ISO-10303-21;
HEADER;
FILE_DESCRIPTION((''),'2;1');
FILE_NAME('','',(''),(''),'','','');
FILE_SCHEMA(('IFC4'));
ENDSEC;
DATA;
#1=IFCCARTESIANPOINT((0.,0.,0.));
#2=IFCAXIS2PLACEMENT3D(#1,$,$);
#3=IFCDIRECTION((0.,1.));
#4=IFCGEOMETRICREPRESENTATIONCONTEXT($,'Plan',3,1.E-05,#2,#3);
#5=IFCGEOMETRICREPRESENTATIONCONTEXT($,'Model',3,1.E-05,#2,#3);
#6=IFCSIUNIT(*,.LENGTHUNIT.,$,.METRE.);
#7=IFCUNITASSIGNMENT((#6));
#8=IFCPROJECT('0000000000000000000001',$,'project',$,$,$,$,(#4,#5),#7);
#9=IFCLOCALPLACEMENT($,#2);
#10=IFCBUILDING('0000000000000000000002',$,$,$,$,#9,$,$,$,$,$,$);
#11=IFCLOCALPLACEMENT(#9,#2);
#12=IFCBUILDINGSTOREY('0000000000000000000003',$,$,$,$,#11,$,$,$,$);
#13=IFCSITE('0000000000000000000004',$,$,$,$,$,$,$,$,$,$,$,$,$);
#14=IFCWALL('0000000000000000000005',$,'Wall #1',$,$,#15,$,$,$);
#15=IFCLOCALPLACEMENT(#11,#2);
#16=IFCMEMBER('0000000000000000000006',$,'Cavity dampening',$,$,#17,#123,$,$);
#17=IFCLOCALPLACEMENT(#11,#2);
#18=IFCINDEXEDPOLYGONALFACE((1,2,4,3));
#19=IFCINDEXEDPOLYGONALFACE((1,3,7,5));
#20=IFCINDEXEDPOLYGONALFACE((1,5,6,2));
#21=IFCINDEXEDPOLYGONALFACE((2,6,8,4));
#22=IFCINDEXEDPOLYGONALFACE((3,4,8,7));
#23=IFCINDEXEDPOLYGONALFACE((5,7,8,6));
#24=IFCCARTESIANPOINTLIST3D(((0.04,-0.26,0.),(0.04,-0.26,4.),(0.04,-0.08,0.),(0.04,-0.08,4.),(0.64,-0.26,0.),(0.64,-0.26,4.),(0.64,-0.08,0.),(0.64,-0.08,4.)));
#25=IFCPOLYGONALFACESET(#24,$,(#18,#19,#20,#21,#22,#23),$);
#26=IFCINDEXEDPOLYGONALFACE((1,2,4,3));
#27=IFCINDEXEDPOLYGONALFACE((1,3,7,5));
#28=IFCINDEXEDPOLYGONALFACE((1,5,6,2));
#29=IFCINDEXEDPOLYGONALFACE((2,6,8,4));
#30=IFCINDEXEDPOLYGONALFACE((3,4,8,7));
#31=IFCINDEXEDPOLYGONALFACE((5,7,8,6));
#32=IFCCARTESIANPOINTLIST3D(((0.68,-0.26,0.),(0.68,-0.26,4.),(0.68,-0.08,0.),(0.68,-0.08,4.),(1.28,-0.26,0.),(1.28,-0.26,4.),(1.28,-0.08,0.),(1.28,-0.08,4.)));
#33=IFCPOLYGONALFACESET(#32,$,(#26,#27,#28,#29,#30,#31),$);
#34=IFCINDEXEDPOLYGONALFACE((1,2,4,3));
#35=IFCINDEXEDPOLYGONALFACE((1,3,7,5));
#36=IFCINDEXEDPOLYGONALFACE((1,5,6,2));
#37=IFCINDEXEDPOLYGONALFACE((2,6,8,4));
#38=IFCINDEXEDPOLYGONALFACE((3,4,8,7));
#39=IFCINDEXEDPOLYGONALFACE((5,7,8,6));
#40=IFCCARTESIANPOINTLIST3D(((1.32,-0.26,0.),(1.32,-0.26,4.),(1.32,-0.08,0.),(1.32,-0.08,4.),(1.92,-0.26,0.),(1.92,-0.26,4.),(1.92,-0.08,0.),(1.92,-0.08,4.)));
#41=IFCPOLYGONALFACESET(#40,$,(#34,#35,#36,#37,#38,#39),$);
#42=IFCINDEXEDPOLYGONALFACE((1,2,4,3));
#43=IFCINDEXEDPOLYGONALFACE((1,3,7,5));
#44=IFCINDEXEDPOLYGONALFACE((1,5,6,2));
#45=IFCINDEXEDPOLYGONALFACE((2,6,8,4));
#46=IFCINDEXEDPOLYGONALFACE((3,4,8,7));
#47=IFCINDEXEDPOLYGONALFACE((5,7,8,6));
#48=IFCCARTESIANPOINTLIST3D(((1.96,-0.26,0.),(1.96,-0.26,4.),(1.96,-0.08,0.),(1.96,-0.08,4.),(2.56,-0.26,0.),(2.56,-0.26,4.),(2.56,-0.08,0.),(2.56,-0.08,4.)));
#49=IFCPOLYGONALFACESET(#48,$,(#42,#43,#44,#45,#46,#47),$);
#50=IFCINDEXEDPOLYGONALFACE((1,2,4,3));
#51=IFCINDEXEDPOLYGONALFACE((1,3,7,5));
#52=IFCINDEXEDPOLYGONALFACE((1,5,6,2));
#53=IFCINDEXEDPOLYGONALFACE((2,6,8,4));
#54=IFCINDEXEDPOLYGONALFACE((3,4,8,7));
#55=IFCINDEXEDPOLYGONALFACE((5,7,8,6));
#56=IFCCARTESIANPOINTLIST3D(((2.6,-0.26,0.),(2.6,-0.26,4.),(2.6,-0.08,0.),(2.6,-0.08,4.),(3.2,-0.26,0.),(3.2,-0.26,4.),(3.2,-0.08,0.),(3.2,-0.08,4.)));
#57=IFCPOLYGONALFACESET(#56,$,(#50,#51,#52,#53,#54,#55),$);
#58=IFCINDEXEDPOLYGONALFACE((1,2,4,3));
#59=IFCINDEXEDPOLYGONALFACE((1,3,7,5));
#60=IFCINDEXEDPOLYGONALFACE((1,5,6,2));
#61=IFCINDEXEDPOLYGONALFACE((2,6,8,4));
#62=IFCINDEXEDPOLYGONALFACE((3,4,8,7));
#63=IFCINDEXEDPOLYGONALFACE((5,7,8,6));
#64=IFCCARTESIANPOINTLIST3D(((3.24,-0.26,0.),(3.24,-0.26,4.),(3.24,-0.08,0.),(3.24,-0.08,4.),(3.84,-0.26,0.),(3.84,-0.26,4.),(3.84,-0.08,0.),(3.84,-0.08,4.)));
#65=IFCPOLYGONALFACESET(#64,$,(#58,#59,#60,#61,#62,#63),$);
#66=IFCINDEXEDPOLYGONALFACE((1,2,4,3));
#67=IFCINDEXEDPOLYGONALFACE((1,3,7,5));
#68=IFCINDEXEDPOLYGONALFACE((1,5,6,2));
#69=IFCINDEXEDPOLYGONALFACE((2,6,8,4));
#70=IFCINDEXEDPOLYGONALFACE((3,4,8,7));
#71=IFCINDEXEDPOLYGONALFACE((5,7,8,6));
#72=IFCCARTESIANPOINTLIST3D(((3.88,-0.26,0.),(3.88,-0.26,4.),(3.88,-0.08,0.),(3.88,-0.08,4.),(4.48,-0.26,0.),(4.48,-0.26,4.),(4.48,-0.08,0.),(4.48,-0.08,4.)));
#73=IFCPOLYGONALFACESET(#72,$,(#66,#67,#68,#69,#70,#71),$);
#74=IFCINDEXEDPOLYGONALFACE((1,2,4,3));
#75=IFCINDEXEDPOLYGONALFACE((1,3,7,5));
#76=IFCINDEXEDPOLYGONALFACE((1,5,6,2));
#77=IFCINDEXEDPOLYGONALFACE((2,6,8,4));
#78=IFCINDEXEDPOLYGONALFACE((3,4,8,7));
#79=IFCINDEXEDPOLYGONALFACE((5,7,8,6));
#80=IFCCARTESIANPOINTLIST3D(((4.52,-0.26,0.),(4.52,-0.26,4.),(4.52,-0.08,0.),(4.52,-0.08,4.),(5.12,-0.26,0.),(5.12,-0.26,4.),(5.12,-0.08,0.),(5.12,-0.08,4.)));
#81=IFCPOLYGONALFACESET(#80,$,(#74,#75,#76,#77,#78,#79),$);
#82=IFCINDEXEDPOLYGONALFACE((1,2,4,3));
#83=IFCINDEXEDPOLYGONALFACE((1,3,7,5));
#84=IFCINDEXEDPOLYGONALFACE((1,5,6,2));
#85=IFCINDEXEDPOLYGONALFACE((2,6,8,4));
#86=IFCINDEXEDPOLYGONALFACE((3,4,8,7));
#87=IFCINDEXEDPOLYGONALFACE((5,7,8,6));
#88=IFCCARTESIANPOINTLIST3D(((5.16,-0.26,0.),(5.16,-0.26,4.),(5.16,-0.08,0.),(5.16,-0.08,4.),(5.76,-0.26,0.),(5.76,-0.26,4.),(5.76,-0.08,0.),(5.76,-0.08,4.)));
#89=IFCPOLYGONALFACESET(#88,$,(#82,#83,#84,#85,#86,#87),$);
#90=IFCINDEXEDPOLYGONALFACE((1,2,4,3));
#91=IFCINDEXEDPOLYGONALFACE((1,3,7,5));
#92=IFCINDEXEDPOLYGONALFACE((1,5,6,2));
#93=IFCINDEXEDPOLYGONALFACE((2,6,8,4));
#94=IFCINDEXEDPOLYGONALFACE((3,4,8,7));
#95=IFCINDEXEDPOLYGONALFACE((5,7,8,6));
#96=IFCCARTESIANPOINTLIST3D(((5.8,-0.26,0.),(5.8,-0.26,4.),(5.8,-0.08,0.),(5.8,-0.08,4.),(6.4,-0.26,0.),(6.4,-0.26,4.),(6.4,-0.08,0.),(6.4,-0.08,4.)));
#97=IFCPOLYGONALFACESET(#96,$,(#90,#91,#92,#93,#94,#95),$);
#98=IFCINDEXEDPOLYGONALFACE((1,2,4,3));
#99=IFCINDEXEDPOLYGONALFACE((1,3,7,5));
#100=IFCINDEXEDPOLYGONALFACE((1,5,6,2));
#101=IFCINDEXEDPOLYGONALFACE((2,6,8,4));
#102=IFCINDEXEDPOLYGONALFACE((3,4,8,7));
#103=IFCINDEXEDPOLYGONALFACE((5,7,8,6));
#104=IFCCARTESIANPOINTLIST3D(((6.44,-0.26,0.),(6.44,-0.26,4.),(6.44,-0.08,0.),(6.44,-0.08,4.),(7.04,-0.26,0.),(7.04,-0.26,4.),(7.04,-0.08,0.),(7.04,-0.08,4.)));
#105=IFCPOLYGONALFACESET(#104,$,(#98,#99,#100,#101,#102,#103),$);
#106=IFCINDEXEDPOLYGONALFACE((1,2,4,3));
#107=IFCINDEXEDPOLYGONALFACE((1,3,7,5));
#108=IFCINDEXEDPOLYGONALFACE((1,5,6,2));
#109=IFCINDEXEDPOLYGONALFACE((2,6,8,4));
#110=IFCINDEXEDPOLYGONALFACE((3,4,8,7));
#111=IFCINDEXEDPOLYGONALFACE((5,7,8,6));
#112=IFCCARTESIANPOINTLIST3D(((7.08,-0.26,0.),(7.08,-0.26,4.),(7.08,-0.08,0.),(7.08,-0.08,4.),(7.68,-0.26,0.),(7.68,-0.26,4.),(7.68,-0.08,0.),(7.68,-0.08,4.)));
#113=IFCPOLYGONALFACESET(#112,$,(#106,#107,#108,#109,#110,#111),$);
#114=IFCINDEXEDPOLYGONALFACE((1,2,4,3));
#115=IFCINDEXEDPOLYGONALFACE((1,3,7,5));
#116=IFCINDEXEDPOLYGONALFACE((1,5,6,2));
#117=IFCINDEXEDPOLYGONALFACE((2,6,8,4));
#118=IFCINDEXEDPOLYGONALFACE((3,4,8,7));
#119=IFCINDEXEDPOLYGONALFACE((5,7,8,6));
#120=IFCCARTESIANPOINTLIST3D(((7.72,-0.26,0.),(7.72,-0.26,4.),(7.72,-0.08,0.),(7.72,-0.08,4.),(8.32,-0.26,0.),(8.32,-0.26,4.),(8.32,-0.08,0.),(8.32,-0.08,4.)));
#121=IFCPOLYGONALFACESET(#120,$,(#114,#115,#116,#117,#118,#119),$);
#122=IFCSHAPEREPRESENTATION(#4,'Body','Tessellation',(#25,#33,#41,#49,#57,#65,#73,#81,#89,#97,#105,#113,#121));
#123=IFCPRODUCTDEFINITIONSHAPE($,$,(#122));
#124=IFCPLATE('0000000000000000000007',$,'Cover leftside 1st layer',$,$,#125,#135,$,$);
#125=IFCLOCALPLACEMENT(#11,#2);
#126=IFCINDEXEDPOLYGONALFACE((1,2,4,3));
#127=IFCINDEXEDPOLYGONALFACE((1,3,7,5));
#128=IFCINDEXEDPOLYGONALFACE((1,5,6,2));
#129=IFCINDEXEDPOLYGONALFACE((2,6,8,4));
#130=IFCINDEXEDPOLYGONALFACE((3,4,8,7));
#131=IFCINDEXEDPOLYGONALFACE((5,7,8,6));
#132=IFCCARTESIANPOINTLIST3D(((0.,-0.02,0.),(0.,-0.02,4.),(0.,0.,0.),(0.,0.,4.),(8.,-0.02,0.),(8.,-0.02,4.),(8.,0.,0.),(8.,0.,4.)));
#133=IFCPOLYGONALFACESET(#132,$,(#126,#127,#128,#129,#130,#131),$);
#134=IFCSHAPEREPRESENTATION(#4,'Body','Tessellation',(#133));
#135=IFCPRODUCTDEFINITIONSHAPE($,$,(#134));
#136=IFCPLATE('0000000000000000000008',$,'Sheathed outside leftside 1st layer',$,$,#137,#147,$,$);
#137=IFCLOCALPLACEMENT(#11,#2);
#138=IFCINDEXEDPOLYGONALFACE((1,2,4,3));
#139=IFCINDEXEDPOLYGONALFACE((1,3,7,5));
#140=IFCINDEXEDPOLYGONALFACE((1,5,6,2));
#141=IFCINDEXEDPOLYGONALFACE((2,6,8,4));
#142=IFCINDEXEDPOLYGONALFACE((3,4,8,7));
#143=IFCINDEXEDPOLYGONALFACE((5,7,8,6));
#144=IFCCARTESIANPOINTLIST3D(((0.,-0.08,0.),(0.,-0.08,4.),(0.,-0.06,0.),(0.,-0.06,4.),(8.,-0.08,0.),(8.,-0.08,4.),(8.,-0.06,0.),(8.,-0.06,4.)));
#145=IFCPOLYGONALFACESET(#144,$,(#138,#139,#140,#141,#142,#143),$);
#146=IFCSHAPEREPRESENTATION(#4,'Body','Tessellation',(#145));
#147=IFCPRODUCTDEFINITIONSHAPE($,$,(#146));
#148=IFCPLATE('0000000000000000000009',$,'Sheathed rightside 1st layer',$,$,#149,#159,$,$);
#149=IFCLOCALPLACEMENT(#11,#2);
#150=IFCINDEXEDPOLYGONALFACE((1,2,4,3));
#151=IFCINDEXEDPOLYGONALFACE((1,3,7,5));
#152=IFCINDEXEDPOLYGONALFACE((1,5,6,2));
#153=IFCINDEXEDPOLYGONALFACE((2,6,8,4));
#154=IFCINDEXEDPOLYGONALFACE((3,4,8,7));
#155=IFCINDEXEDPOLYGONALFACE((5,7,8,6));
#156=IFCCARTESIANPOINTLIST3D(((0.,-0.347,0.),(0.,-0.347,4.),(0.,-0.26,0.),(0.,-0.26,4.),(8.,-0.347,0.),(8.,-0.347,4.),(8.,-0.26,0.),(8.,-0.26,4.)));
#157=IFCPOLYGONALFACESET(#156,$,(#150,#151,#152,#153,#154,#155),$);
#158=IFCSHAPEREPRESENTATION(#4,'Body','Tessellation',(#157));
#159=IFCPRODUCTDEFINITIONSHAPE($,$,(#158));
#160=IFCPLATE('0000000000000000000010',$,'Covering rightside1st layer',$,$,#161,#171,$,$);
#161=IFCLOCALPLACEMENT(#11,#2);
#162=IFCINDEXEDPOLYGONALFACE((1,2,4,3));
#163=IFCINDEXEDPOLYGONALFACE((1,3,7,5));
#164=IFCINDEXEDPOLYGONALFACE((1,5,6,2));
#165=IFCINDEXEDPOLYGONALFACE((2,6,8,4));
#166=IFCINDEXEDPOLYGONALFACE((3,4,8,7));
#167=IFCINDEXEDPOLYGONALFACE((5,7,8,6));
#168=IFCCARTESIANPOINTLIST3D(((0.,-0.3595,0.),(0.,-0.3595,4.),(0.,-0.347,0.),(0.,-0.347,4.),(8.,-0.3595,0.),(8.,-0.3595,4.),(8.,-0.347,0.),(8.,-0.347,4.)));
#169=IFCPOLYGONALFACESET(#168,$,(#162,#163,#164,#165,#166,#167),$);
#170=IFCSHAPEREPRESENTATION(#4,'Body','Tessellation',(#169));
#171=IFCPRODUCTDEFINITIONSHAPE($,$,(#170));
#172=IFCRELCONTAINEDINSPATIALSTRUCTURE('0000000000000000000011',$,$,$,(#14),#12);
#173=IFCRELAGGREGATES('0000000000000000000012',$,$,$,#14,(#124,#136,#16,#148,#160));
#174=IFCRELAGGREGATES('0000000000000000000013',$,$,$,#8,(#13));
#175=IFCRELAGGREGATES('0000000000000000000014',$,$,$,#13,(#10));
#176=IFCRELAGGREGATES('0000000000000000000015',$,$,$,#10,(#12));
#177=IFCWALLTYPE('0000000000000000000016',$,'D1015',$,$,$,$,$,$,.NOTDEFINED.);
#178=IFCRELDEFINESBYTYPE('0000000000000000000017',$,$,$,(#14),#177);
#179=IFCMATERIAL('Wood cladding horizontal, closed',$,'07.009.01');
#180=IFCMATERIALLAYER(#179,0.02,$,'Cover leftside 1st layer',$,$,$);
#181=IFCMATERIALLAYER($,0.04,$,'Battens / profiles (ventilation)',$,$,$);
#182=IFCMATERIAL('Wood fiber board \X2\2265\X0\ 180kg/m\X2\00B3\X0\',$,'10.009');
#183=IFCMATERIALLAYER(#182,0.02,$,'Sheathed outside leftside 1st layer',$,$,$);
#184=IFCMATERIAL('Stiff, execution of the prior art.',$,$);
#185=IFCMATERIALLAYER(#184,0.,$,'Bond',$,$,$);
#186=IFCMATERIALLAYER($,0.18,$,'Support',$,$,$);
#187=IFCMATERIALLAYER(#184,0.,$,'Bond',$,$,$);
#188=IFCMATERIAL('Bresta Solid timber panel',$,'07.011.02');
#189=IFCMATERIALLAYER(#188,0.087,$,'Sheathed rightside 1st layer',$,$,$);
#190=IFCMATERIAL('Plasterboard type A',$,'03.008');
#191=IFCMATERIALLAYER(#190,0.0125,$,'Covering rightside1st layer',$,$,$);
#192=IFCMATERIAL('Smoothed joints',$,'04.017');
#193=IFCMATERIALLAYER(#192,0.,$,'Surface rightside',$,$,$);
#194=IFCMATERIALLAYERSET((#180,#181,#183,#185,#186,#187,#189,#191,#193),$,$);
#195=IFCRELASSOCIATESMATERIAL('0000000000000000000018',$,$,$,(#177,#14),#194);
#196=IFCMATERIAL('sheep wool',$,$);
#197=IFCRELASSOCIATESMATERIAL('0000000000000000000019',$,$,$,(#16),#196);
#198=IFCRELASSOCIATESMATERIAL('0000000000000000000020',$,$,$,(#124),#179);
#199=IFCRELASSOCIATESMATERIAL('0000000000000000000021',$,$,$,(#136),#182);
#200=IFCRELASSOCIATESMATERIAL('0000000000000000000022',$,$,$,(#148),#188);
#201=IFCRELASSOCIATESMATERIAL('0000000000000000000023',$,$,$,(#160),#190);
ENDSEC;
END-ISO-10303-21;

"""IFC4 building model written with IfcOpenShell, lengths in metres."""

from ifc_helpers import new_model, si_unit, direction, frame, frame_2d, origin, origin_with_axes, place, context, project, spatial, rectangle, extrude, material, layer, layer_set, type_object, element, aggregate, save


model = new_model("IFC4")

# Units and contexts
plan_context = context("Plan", 3, precision=1e-05, world=origin(), true_north=direction((0.0, 1.0)))
model_context = context("Model", 3, precision=1e-05, world=origin(), true_north=direction((0.0, 1.0)))
ifc_project = project(units=[si_unit("LENGTHUNIT", "METRE")], contexts=[plan_context, model_context])

# Site, building, storey
site = spatial("IfcSite", under=ifc_project)
building_placement = place(None, origin())
building = spatial("IfcBuilding", under=site, at=building_placement)
storey_placement = place(building_placement, origin())
storey = spatial("IfcBuildingStorey", under=building, at=storey_placement)

# Wall, member, plates
ifc_material_1 = material(Name="Wood cladding horizontal, closed", Category="07.009.01")
ifc_layer_1 = layer(ifc_material_1, 0.02, Name="Cover leftside 1st layer")
ifc_layer_2 = layer(None, 0.04, Name="Battens / profiles (ventilation)")
ifc_material_2 = material(Name="Wood fiber board ≥ 180kg/m³", Category="10.009")
ifc_layer_3 = layer(ifc_material_2, 0.02, Name="Sheathed outside leftside 1st layer")
ifc_material_3 = material(Name="Stiff, execution of the prior art.")
ifc_layer_4 = layer(ifc_material_3, 0.0, Name="Bond")
ifc_layer_5 = layer(None, 0.18, Name="Support")
ifc_layer_6 = layer(ifc_material_3, 0.0, Name="Bond")
ifc_material_4 = material(Name="Bresta Solid timber panel", Category="07.011.02")
ifc_layer_7 = layer(ifc_material_4, 0.087, Name="Sheathed rightside 1st layer")
ifc_material_5 = material(Name="Plasterboard type A", Category="03.008")
ifc_layer_8 = layer(ifc_material_5, 0.0125, Name="Covering rightside1st layer")
ifc_material_6 = material(Name="Smoothed joints", Category="04.017")
ifc_layer_9 = layer(ifc_material_6, 0.0, Name="Surface rightside")
ifc_layer_set = layer_set([ifc_layer_1, ifc_layer_2, ifc_layer_3, ifc_layer_4, ifc_layer_5, ifc_layer_6, ifc_layer_7, ifc_layer_8, ifc_layer_9])
wall_type = type_object("IfcWallType", Name="D1015", PredefinedType="NOTDEFINED", material=ifc_layer_set)
wall_placement = place(None, frame((0.0, 0.0, 0.0), z_axis=(0.0, -1.0, 0.0), x_axis=(1.0, 0.0, 0.0)))
wall = element("IfcWall", 1, at=wall_placement, inside=storey, type_object=wall_type, material=ifc_layer_set, Name="Wall #1")
ifc_material_7 = material(Name="sheep wool")
member_1_placement = place(wall_placement, origin())
member_1 = element("IfcMember", 2, at=member_1_placement, material=ifc_material_7, Name="Cavity dampening", context=plan_context, shape_type="SweptSolid", body=[
    extrude(rectangle(XDim=0.6, YDim=0.18, at=frame_2d((0.3, 0.09), x_axis=(1.0, 0.0))), frame((0.04, 4.0, 0.08), z_axis=(0.0, -1.0, 0.0), x_axis=(1.0, 0.0, 0.0)), (0.0, 0.0, 1.0), 4.0),
    extrude(rectangle(XDim=0.6, YDim=0.18, at=frame_2d((0.3, 0.09), x_axis=(1.0, 0.0))), frame((0.68, 4.0, 0.08), z_axis=(0.0, -1.0, 0.0), x_axis=(1.0, 0.0, 0.0)), (0.0, 0.0, 1.0), 4.0),
    extrude(rectangle(XDim=0.6, YDim=0.18, at=frame_2d((0.3, 0.09), x_axis=(1.0, 0.0))), frame((1.32, 4.0, 0.08), z_axis=(0.0, -1.0, 0.0), x_axis=(1.0, 0.0, 0.0)), (0.0, 0.0, 1.0), 4.0),
    extrude(rectangle(XDim=0.6, YDim=0.18, at=frame_2d((0.3, 0.09), x_axis=(1.0, 0.0))), frame((1.96, 4.0, 0.08), z_axis=(0.0, -1.0, 0.0), x_axis=(1.0, 0.0, 0.0)), (0.0, 0.0, 1.0), 4.0),
    extrude(rectangle(XDim=0.6, YDim=0.18, at=frame_2d((0.3, 0.09), x_axis=(1.0, 0.0))), frame((2.6, 4.0, 0.08), z_axis=(0.0, -1.0, 0.0), x_axis=(1.0, 0.0, 0.0)), (0.0, 0.0, 1.0), 4.0),
    extrude(rectangle(XDim=0.6, YDim=0.18, at=frame_2d((0.3, 0.09), x_axis=(1.0, 0.0))), frame((3.24, 4.0, 0.08), z_axis=(0.0, -1.0, 0.0), x_axis=(1.0, 0.0, 0.0)), (0.0, 0.0, 1.0), 4.0),
    extrude(rectangle(XDim=0.6, YDim=0.18, at=frame_2d((0.3, 0.09), x_axis=(1.0, 0.0))), frame((3.88, 4.0, 0.08), z_axis=(0.0, -1.0, 0.0), x_axis=(1.0, 0.0, 0.0)), (0.0, 0.0, 1.0), 4.0),
    extrude(rectangle(XDim=0.6, YDim=0.18, at=frame_2d((0.3, 0.09), x_axis=(1.0, 0.0))), frame((4.52, 4.0, 0.08), z_axis=(0.0, -1.0, 0.0), x_axis=(1.0, 0.0, 0.0)), (0.0, 0.0, 1.0), 4.0),
    extrude(rectangle(XDim=0.6, YDim=0.18, at=frame_2d((0.3, 0.09), x_axis=(1.0, 0.0))), frame((5.16, 4.0, 0.08), z_axis=(0.0, -1.0, 0.0), x_axis=(1.0, 0.0, 0.0)), (0.0, 0.0, 1.0), 4.0),
    extrude(rectangle(XDim=0.6, YDim=0.18, at=frame_2d((0.3, 0.09), x_axis=(1.0, 0.0))), frame((5.8, 4.0, 0.08), z_axis=(0.0, -1.0, 0.0), x_axis=(1.0, 0.0, 0.0)), (0.0, 0.0, 1.0), 4.0),
    extrude(rectangle(XDim=0.6, YDim=0.18, at=frame_2d((0.3, 0.09), x_axis=(1.0, 0.0))), frame((6.44, 4.0, 0.08), z_axis=(0.0, -1.0, 0.0), x_axis=(1.0, 0.0, 0.0)), (0.0, 0.0, 1.0), 4.0),
    extrude(rectangle(XDim=0.6, YDim=0.18, at=frame_2d((0.3, 0.09), x_axis=(1.0, 0.0))), frame((7.08, 4.0, 0.08), z_axis=(0.0, -1.0, 0.0), x_axis=(1.0, 0.0, 0.0)), (0.0, 0.0, 1.0), 4.0),
    extrude(rectangle(XDim=0.6, YDim=0.18, at=frame_2d((0.3, 0.09), x_axis=(1.0, 0.0))), frame((7.72, 4.0, 0.08), z_axis=(0.0, -1.0, 0.0), x_axis=(1.0, 0.0, 0.0)), (0.0, 0.0, 1.0), 4.0),
])
plate_1_placement = place(wall_placement, origin())
plate_1 = element("IfcPlate", 3, at=plate_1_placement, material=ifc_material_1, Name="Cover leftside 1st layer", context=plan_context, shape_type="SweptSolid", body=[
    extrude(rectangle(XDim=8.0, YDim=4.0, at=frame_2d((4.0, 2.0), x_axis=(1.0, 0.0))), origin_with_axes(), (0.0, 0.0, 1.0), 0.02),
])
plate_2_placement = place(wall_placement, origin())
plate_2 = element("IfcPlate", 4, at=plate_2_placement, material=ifc_material_2, Name="Sheathed outside leftside 1st layer", context=plan_context, shape_type="SweptSolid", body=[
    extrude(rectangle(XDim=8.0, YDim=4.0, at=frame_2d((4.0, 2.0), x_axis=(1.0, 0.0))), frame((0.0, 0.0, 0.06), z_axis=(0.0, 0.0, 1.0), x_axis=(1.0, 0.0, 0.0)), (0.0, 0.0, 1.0), 0.02),
])
plate_3_placement = place(wall_placement, origin())
plate_3 = element("IfcPlate", 5, at=plate_3_placement, material=ifc_material_4, Name="Sheathed rightside 1st layer", context=plan_context, shape_type="SweptSolid", body=[
    extrude(rectangle(XDim=8.0, YDim=4.0, at=frame_2d((4.0, 2.0), x_axis=(1.0, 0.0))), frame((0.0, 0.0, 0.26), z_axis=(0.0, 0.0, 1.0), x_axis=(1.0, 0.0, 0.0)), (0.0, 0.0, 1.0), 0.087),
])
plate_4_placement = place(wall_placement, origin())
plate_4 = element("IfcPlate", 6, at=plate_4_placement, material=ifc_material_5, Name="Covering rightside1st layer", context=plan_context, shape_type="SweptSolid", body=[
    extrude(rectangle(XDim=8.0, YDim=4.0, at=frame_2d((4.0, 2.0), x_axis=(1.0, 0.0))), frame((0.0, 0.0, 0.347), z_axis=(0.0, 0.0, 1.0), x_axis=(1.0, 0.0, 0.0)), (0.0, 0.0, 1.0), 0.0125),
])
aggregate(wall, [plate_1, plate_2, member_1, plate_3, plate_4])

save(model, "model.ifc")
